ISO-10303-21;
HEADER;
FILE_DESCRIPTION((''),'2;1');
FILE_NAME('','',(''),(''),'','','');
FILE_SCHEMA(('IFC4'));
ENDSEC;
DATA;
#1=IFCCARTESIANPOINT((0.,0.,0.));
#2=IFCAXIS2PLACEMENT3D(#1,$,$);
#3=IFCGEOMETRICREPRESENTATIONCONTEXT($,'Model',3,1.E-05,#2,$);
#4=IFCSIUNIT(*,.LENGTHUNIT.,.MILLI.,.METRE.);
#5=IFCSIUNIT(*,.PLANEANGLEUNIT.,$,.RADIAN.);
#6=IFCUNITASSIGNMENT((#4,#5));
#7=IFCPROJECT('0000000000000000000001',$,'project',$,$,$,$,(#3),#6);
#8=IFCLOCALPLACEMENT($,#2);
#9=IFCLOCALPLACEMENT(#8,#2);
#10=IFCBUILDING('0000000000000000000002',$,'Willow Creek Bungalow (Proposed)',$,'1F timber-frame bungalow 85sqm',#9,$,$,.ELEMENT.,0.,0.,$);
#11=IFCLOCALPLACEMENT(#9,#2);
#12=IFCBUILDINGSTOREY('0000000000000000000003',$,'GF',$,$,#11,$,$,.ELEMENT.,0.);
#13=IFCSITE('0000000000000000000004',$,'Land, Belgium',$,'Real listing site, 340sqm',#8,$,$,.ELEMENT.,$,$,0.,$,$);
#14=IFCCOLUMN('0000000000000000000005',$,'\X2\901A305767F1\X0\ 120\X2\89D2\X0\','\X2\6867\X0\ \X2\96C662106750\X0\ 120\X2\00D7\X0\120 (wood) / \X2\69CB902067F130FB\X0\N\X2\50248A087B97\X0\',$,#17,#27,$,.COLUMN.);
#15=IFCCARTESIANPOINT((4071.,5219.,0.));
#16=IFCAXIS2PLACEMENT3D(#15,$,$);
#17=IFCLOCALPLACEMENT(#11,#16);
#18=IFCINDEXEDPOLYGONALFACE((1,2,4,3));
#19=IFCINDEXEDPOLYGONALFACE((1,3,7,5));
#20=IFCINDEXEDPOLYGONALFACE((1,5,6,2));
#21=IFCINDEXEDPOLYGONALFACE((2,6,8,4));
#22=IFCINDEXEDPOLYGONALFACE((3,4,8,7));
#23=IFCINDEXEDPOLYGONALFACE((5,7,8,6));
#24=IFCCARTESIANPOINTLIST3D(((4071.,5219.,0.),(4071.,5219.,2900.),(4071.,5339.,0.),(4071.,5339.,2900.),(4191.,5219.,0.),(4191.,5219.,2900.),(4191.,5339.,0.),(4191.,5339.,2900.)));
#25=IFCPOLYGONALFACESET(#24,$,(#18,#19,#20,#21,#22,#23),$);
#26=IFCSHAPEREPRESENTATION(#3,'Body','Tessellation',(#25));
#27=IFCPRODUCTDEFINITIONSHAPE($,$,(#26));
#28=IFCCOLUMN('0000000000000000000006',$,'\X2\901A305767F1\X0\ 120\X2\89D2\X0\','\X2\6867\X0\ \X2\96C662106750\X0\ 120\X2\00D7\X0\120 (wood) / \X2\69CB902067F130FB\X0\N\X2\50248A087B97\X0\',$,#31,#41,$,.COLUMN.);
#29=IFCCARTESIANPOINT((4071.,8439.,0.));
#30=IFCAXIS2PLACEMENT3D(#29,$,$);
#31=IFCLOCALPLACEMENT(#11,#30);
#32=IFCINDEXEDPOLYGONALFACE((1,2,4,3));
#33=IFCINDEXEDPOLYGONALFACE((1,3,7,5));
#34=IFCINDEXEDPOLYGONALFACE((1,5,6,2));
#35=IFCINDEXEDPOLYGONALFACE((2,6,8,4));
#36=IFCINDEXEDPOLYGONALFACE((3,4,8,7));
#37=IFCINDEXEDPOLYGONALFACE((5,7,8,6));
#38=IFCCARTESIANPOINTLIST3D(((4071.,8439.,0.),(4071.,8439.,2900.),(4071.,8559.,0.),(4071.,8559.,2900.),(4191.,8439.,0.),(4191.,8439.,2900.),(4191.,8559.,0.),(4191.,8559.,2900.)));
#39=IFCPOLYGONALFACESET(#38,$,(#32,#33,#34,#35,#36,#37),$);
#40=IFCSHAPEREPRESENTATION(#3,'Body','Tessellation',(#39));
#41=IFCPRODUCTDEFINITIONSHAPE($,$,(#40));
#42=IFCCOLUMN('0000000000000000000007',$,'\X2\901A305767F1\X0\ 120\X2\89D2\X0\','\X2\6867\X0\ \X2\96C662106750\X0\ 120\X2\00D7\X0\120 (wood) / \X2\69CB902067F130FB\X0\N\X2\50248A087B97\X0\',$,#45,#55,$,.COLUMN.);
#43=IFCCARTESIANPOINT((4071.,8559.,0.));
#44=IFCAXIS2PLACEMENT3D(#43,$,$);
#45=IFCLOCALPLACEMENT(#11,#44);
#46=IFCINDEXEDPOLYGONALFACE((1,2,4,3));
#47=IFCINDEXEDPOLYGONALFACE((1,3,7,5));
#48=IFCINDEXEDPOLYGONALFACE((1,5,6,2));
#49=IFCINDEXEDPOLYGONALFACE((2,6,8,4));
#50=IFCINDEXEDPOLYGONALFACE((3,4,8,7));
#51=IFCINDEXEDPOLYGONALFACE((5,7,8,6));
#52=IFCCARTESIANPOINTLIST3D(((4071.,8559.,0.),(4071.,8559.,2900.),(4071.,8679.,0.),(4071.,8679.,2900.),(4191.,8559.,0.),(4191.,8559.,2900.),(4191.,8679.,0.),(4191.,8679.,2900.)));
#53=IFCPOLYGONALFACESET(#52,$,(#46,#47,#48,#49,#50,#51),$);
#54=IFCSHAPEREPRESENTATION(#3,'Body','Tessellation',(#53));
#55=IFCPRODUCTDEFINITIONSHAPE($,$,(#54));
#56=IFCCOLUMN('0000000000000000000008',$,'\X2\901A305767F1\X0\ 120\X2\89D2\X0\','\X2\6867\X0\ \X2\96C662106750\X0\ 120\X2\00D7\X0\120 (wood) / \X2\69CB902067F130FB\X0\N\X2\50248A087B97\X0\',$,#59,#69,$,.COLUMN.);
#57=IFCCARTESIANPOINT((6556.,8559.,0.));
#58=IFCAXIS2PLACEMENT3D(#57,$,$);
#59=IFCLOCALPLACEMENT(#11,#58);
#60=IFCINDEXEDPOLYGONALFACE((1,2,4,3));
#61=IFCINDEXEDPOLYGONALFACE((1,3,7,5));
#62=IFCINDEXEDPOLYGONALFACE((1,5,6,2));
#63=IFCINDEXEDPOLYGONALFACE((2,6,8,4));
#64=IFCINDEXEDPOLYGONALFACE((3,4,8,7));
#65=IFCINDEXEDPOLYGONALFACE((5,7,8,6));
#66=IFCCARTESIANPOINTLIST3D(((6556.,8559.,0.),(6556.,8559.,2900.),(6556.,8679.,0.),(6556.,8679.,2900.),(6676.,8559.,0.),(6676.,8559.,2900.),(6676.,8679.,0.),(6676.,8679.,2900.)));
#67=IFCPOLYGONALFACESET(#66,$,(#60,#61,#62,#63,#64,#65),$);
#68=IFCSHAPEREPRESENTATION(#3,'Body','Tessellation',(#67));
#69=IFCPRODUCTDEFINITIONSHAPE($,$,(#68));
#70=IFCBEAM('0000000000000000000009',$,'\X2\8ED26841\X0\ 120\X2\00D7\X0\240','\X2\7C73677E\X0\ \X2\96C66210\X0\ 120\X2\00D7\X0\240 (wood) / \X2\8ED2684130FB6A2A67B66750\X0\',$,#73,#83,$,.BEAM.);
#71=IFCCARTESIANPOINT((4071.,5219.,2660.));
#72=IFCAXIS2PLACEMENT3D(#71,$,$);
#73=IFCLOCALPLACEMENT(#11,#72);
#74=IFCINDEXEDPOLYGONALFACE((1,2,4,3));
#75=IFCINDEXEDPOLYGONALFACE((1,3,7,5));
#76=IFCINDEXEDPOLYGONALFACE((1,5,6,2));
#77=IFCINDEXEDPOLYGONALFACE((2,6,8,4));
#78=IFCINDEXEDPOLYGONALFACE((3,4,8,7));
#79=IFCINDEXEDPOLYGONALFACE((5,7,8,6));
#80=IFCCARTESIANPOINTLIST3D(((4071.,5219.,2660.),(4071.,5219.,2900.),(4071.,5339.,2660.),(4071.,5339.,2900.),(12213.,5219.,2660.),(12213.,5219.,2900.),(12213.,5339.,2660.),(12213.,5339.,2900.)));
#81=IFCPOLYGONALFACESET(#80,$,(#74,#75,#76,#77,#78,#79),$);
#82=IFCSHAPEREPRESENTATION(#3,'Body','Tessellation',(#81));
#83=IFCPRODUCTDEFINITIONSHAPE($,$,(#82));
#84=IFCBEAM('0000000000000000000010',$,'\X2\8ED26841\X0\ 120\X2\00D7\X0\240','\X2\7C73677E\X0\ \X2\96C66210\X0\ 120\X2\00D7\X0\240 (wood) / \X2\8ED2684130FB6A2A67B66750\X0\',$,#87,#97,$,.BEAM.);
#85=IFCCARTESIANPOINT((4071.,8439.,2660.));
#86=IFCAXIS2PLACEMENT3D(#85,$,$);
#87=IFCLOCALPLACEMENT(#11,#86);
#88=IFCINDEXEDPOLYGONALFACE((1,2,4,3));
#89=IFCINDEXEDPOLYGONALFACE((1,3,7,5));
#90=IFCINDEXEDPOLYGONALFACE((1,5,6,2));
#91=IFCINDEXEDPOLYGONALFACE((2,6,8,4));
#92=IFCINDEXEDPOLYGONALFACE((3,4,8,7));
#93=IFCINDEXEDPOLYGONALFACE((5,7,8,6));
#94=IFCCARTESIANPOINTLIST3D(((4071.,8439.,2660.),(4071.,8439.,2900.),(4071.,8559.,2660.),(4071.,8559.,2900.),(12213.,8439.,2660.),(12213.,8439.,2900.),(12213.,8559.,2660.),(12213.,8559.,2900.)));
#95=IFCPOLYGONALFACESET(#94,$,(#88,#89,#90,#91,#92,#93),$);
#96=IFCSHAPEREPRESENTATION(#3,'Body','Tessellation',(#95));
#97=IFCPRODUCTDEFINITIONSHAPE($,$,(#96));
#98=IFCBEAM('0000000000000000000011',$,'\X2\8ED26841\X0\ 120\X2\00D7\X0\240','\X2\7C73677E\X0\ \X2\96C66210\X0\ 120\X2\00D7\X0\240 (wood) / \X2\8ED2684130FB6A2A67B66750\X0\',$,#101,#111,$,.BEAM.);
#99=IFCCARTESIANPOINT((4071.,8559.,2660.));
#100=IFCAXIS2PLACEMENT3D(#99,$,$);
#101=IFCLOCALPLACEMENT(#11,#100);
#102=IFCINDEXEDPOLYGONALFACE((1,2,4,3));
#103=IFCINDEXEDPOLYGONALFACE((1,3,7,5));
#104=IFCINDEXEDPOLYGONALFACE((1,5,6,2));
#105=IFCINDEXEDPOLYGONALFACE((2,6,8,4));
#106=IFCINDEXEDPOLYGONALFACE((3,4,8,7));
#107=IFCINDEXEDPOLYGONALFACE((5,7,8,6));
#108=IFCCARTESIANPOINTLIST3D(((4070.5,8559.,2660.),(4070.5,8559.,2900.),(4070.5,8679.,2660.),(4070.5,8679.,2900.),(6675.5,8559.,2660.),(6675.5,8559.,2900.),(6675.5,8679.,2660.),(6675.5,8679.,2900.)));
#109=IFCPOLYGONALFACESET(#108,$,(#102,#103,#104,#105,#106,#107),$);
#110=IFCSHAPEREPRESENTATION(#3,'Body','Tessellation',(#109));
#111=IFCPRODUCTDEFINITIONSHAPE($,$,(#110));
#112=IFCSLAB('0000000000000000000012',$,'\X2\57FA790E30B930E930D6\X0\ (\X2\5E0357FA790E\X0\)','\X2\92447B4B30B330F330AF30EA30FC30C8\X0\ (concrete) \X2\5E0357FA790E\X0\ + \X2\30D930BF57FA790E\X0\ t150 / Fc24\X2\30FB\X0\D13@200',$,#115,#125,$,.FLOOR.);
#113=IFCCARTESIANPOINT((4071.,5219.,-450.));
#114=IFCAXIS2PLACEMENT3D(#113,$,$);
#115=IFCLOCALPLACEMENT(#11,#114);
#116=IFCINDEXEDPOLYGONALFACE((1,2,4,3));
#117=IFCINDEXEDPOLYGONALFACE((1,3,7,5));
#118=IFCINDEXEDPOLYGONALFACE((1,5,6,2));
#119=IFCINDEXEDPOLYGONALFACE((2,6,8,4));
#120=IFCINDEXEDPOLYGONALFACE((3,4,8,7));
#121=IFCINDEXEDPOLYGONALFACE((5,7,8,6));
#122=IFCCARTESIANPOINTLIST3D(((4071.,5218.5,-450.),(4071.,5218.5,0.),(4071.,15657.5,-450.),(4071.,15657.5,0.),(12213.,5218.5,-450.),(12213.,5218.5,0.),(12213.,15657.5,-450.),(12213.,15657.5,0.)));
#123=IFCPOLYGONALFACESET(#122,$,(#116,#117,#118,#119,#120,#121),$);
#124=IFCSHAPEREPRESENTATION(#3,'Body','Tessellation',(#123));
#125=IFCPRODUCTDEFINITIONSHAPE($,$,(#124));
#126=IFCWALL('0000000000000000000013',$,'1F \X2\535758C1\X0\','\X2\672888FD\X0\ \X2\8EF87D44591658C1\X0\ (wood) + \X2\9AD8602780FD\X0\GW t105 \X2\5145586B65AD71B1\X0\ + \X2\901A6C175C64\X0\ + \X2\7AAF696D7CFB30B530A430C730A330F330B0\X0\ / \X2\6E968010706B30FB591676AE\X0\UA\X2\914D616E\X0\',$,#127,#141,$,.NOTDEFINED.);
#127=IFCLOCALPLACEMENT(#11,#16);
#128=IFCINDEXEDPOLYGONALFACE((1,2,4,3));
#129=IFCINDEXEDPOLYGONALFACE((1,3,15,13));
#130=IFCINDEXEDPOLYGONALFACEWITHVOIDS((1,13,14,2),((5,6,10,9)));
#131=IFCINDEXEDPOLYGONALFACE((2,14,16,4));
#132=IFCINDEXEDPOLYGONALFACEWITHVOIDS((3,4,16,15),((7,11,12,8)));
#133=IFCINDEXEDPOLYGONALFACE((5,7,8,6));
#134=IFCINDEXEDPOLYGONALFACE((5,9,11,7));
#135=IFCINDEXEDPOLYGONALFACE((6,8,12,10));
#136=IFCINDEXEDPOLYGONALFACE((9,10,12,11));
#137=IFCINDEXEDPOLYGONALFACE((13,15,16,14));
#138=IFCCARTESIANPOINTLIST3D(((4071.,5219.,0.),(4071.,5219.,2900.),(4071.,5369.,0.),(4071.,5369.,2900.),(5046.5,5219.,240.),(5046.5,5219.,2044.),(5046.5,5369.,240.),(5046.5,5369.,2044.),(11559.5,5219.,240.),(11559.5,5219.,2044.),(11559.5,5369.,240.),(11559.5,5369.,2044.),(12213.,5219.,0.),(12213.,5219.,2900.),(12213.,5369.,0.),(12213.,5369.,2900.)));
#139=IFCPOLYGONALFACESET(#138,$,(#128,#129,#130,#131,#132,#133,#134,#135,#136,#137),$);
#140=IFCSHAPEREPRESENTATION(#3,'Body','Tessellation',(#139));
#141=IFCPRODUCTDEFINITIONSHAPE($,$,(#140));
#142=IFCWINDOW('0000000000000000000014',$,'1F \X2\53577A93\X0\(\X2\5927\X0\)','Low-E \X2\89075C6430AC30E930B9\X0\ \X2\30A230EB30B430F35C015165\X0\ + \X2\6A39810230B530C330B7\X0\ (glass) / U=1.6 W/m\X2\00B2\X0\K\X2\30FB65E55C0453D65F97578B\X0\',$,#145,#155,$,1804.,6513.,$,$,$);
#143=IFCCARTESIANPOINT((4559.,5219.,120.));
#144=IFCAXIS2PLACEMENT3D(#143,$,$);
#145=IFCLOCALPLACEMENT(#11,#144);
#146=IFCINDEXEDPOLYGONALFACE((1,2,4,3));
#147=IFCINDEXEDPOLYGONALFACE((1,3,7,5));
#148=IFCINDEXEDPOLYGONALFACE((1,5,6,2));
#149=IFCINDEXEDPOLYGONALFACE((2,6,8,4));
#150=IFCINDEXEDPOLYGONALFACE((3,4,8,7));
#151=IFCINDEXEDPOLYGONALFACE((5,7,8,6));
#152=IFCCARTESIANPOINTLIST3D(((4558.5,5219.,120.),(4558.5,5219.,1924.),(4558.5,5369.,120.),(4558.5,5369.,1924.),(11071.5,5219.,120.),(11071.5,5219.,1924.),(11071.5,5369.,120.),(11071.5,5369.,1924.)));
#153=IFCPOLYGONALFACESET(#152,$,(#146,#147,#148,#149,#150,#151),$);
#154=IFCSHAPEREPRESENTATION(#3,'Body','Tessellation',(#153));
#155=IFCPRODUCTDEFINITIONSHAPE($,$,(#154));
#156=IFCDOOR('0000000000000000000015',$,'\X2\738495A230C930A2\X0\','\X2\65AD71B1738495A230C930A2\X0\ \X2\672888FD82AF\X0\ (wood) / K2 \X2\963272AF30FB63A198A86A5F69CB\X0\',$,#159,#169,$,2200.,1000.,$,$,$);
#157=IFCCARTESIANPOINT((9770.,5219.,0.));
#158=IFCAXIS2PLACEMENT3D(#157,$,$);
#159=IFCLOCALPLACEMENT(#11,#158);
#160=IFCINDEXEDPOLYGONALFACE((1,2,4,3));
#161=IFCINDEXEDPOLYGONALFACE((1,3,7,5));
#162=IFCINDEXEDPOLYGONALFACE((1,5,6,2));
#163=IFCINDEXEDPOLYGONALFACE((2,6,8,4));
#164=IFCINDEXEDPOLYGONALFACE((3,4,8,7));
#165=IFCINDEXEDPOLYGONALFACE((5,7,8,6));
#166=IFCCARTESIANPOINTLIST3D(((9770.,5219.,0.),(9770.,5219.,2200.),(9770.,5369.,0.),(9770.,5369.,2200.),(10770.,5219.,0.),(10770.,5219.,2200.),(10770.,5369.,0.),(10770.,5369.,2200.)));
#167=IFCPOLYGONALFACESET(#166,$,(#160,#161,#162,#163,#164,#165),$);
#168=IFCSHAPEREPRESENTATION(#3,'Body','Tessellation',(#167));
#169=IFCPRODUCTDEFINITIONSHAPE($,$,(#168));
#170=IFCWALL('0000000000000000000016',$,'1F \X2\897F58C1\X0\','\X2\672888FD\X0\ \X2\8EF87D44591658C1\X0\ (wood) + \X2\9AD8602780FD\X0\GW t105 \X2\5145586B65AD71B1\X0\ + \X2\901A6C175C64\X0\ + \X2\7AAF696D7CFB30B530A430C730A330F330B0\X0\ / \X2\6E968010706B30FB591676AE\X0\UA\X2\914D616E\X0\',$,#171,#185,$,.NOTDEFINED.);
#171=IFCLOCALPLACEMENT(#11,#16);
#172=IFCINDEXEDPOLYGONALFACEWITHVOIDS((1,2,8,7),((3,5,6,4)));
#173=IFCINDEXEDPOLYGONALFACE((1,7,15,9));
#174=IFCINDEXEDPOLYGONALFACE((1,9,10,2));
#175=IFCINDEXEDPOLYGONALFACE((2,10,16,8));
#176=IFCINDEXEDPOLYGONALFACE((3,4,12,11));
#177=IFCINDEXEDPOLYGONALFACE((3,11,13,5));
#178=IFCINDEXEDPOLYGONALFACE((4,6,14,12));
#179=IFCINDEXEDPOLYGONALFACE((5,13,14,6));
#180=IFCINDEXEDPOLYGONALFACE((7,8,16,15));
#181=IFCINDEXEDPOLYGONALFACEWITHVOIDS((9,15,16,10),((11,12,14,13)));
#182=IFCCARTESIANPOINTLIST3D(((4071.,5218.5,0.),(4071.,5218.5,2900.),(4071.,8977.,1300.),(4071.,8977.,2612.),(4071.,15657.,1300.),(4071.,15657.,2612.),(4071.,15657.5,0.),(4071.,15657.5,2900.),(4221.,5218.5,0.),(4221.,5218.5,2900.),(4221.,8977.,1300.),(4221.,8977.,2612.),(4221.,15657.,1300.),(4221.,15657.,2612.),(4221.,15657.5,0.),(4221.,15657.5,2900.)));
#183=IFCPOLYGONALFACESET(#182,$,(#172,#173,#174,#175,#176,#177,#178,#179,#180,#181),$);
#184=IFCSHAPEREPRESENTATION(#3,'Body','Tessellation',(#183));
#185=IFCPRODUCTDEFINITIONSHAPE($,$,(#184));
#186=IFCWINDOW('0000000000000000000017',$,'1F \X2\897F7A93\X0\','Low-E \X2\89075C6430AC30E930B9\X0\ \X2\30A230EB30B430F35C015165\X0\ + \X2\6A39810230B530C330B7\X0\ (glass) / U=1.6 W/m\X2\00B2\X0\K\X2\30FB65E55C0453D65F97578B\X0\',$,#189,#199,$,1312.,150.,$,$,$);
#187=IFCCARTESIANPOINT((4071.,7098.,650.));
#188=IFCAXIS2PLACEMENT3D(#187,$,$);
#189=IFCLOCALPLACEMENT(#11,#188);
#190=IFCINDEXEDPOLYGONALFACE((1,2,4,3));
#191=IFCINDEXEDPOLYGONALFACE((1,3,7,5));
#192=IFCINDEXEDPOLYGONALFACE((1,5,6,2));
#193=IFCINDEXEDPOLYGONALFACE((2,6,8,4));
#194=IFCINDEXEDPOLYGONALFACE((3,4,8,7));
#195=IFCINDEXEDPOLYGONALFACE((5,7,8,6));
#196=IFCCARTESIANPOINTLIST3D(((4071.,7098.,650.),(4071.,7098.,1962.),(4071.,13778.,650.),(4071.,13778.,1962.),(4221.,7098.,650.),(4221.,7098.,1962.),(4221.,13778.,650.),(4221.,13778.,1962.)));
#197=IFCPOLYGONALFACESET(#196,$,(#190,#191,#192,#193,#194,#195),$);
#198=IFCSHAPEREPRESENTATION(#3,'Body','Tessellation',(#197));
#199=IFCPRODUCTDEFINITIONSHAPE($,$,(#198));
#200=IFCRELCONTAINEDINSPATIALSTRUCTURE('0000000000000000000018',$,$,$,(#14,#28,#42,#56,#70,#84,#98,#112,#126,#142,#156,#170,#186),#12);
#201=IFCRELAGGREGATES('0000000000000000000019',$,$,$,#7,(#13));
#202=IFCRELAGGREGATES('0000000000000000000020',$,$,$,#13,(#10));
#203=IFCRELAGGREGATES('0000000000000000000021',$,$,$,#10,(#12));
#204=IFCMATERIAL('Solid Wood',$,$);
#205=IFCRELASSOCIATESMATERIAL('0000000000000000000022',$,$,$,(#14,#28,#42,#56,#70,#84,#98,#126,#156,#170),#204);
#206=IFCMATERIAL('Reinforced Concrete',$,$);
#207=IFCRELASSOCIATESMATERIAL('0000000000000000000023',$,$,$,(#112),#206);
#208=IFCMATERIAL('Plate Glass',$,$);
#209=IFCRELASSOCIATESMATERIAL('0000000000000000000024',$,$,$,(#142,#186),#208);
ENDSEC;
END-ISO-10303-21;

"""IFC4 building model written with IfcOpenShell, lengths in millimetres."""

from ifc_helpers import new_model, si_unit, frame, frame_2d, origin, place, context, project, spatial, rectangle, extrude, material, element, fill, save


model = new_model("IFC4")

# Units and contexts
model_context = context("Model", 3, precision=1e-05, world=origin())
ifc_project = project(units=[si_unit("LENGTHUNIT", "METRE", prefix="MILLI"), si_unit("PLANEANGLEUNIT", "RADIAN")], contexts=[model_context])

# Site, building, storey
site_placement = place(None, origin())
site = spatial("IfcSite", under=ifc_project, at=site_placement, Name="Land, Belgium", ObjectType="Real listing site, 340sqm", CompositionType="ELEMENT", RefElevation=0.0)
building_placement = place(site_placement, origin())
building = spatial("IfcBuilding", under=site, at=building_placement, Name="Willow Creek Bungalow (Proposed)", ObjectType="1F timber-frame bungalow 85sqm", CompositionType="ELEMENT", ElevationOfRefHeight=0.0, ElevationOfTerrain=0.0)
storey_placement = place(building_placement, origin())
storey = spatial("IfcBuildingStorey", under=building, at=storey_placement, Name="GF", CompositionType="ELEMENT", Elevation=0.0)

# Columns
ifc_material_1 = material(Name="Solid Wood")
column_1_placement = place(storey_placement, frame((4071.0, 5219.0, 0.0)))
element("IfcColumn", 1, at=column_1_placement, inside=storey, material=ifc_material_1, Name="通し柱 120角", Description="桧 集成材 120×120 (wood) / 構造柱・N値計算", PredefinedType="COLUMN", context=model_context, shape_type="SweptSolid", body=[
    extrude(rectangle(XDim=120.0, YDim=120.0, at=frame_2d((60.0, 60.0))), frame((4071.0, 5219.0, 0.0)), (0.0, 0.0, 1.0), 2900.0),
])
column_2_placement = place(storey_placement, frame((4071.0, 8439.0, 0.0)))
element("IfcColumn", 2, at=column_2_placement, inside=storey, material=ifc_material_1, Name="通し柱 120角", Description="桧 集成材 120×120 (wood) / 構造柱・N値計算", PredefinedType="COLUMN", context=model_context, shape_type="SweptSolid", body=[
    extrude(rectangle(XDim=120.0, YDim=120.0, at=frame_2d((60.0, 60.0))), frame((4071.0, 8439.0, 0.0)), (0.0, 0.0, 1.0), 2900.0),
])
column_3_placement = place(storey_placement, frame((4071.0, 8559.0, 0.0)))
element("IfcColumn", 3, at=column_3_placement, inside=storey, material=ifc_material_1, Name="通し柱 120角", Description="桧 集成材 120×120 (wood) / 構造柱・N値計算", PredefinedType="COLUMN", context=model_context, shape_type="SweptSolid", body=[
    extrude(rectangle(XDim=120.0, YDim=120.0, at=frame_2d((60.0, 60.0))), frame((4071.0, 8559.0, 0.0)), (0.0, 0.0, 1.0), 2900.0),
])
column_4_placement = place(storey_placement, frame((6556.0, 8559.0, 0.0)))
element("IfcColumn", 4, at=column_4_placement, inside=storey, material=ifc_material_1, Name="通し柱 120角", Description="桧 集成材 120×120 (wood) / 構造柱・N値計算", PredefinedType="COLUMN", context=model_context, shape_type="SweptSolid", body=[
    extrude(rectangle(XDim=120.0, YDim=120.0, at=frame_2d((60.0, 60.0))), frame((6556.0, 8559.0, 0.0)), (0.0, 0.0, 1.0), 2900.0),
])

# Beams
beam_1_placement = place(storey_placement, frame((4071.0, 5219.0, 2660.0)))
element("IfcBeam", 5, at=beam_1_placement, inside=storey, material=ifc_material_1, Name="軒桁 120×240", Description="米松 集成 120×240 (wood) / 軒桁・横架材", PredefinedType="BEAM", context=model_context, shape_type="SweptSolid", body=[
    extrude(rectangle(XDim=8142.0, YDim=120.0, at=frame_2d((4071.0, 60.0))), frame((4071.0, 5219.0, 2660.0)), (0.0, 0.0, 1.0), 240.0),
])
beam_2_placement = place(storey_placement, frame((4071.0, 8439.0, 2660.0)))
element("IfcBeam", 6, at=beam_2_placement, inside=storey, material=ifc_material_1, Name="軒桁 120×240", Description="米松 集成 120×240 (wood) / 軒桁・横架材", PredefinedType="BEAM", context=model_context, shape_type="SweptSolid", body=[
    extrude(rectangle(XDim=8142.0, YDim=120.0, at=frame_2d((4071.0, 60.0))), frame((4071.0, 8439.0, 2660.0)), (0.0, 0.0, 1.0), 240.0),
])
beam_3_placement = place(storey_placement, frame((4071.0, 8559.0, 2660.0)))
element("IfcBeam", 7, at=beam_3_placement, inside=storey, material=ifc_material_1, Name="軒桁 120×240", Description="米松 集成 120×240 (wood) / 軒桁・横架材", PredefinedType="BEAM", context=model_context, shape_type="SweptSolid", body=[
    extrude(rectangle(XDim=2605.0, YDim=120.0, at=frame_2d((1302.0, 60.0))), frame((4071.0, 8559.0, 2660.0)), (0.0, 0.0, 1.0), 240.0),
])

# Slab
ifc_material_2 = material(Name="Reinforced Concrete")
slab_1_placement = place(storey_placement, frame((4071.0, 5219.0, -450.0)))
element("IfcSlab", 8, at=slab_1_placement, inside=storey, material=ifc_material_2, Name="基礎スラブ (布基礎)", Description="鉄筋コンクリート (concrete) 布基礎 + ベタ基礎 t150 / Fc24・D13@200", PredefinedType="FLOOR", context=model_context, shape_type="SweptSolid", body=[
    extrude(rectangle(XDim=8142.0, YDim=10439.0, at=frame_2d((4071.0, 5219.0))), frame((4071.0, 5219.0, -450.0)), (0.0, 0.0, 1.0), 450.0),
])

# Wall, openings, window, door
wall_1_placement = place(storey_placement, frame((4071.0, 5219.0, 0.0)))
wall_1 = element("IfcWall", 9, at=wall_1_placement, inside=storey, material=ifc_material_1, Name="1F 南壁", Description="木製 軸組外壁 (wood) + 高性能GW t105 充填断熱 + 通気層 + 窯業系サイディング / 準耐火・外皮UA配慮", PredefinedType="NOTDEFINED", context=model_context, shape_type="SweptSolid", body=[
    extrude(rectangle(XDim=8142.0, YDim=150.0, at=frame_2d((4071.0, 75.0))), frame((4071.0, 5219.0, 0.0)), (0.0, 0.0, 1.0), 2900.0),
])
opening_1_placement = place(storey_placement, frame((4559.0, 5219.0, 120.0)))
opening_1 = element("IfcOpeningElement", 10, at=opening_1_placement, cuts=wall_1, PredefinedType="NOTDEFINED", context=model_context, shape_type="SweptSolid", body=[
    extrude(rectangle(XDim=6513.0, YDim=150.0, at=frame_2d((3256.0, 75.0))), frame((4559.0, 5219.0, 120.0)), (0.0, 0.0, 1.0), 1804.0),
])
opening_2_placement = place(storey_placement, frame((9770.0, 5219.0, 0.0)))
opening_2 = element("IfcOpeningElement", 11, at=opening_2_placement, cuts=wall_1, PredefinedType="NOTDEFINED", context=model_context, shape_type="SweptSolid", body=[
    extrude(rectangle(XDim=1000.0, YDim=150.0, at=frame_2d((500.0, 75.0))), frame((9770.0, 5219.0, 0.0)), (0.0, 0.0, 1.0), 2200.0),
])
ifc_material_3 = material(Name="Plate Glass")
window_1_placement = place(storey_placement, frame((4559.0, 5219.0, 120.0)))
window_1 = element("IfcWindow", 12, at=window_1_placement, inside=storey, material=ifc_material_3, Name="1F 南窓(大)", Description="Low-E 複層ガラス アルゴン封入 + 樹脂サッシ (glass) / U=1.6 W/m²K・日射取得型", OverallHeight=1804.0, OverallWidth=6513.0, context=model_context, shape_type="SweptSolid", body=[
    extrude(rectangle(XDim=6513.0, YDim=150.0, at=frame_2d((3256.0, 75.0))), frame((4559.0, 5219.0, 120.0)), (0.0, 0.0, 1.0), 1804.0),
])
fill(opening_1, window_1)
door_placement = place(storey_placement, frame((9770.0, 5219.0, 0.0)))
door = element("IfcDoor", 13, at=door_placement, inside=storey, material=ifc_material_1, Name="玄関ドア", Description="断熱玄関ドア 木製芯 (wood) / K2 防犯・採風機構", OverallHeight=2200.0, OverallWidth=1000.0, context=model_context, shape_type="SweptSolid", body=[
    extrude(rectangle(XDim=1000.0, YDim=150.0, at=frame_2d((500.0, 75.0))), frame((9770.0, 5219.0, 0.0)), (0.0, 0.0, 1.0), 2200.0),
])
fill(opening_2, door)

# Wall, opening, window
wall_2_placement = place(storey_placement, frame((4071.0, 5219.0, 0.0)))
wall_2 = element("IfcWall", 14, at=wall_2_placement, inside=storey, material=ifc_material_1, Name="1F 西壁", Description="木製 軸組外壁 (wood) + 高性能GW t105 充填断熱 + 通気層 + 窯業系サイディング / 準耐火・外皮UA配慮", PredefinedType="NOTDEFINED", context=model_context, shape_type="SweptSolid", body=[
    extrude(rectangle(XDim=150.0, YDim=10439.0, at=frame_2d((75.0, 5219.0))), frame((4071.0, 5219.0, 0.0)), (0.0, 0.0, 1.0), 2900.0),
])
opening_3_placement = place(storey_placement, frame((4071.0, 7098.0, 650.0)))
opening_3 = element("IfcOpeningElement", 15, at=opening_3_placement, cuts=wall_2, PredefinedType="NOTDEFINED", context=model_context, shape_type="SweptSolid", body=[
    extrude(rectangle(XDim=150.0, YDim=6680.0, at=frame_2d((75.0, 3340.0))), frame((4071.0, 7098.0, 650.0)), (0.0, 0.0, 1.0), 1312.0),
])
window_2_placement = place(storey_placement, frame((4071.0, 7098.0, 650.0)))
window_2 = element("IfcWindow", 16, at=window_2_placement, inside=storey, material=ifc_material_3, Name="1F 西窓", Description="Low-E 複層ガラス アルゴン封入 + 樹脂サッシ (glass) / U=1.6 W/m²K・日射取得型", OverallHeight=1312.0, OverallWidth=150.0, context=model_context, shape_type="SweptSolid", body=[
    extrude(rectangle(XDim=150.0, YDim=6680.0, at=frame_2d((75.0, 3340.0))), frame((4071.0, 7098.0, 650.0)), (0.0, 0.0, 1.0), 1312.0),
])
fill(opening_3, window_2)

save(model, "model.ifc")
